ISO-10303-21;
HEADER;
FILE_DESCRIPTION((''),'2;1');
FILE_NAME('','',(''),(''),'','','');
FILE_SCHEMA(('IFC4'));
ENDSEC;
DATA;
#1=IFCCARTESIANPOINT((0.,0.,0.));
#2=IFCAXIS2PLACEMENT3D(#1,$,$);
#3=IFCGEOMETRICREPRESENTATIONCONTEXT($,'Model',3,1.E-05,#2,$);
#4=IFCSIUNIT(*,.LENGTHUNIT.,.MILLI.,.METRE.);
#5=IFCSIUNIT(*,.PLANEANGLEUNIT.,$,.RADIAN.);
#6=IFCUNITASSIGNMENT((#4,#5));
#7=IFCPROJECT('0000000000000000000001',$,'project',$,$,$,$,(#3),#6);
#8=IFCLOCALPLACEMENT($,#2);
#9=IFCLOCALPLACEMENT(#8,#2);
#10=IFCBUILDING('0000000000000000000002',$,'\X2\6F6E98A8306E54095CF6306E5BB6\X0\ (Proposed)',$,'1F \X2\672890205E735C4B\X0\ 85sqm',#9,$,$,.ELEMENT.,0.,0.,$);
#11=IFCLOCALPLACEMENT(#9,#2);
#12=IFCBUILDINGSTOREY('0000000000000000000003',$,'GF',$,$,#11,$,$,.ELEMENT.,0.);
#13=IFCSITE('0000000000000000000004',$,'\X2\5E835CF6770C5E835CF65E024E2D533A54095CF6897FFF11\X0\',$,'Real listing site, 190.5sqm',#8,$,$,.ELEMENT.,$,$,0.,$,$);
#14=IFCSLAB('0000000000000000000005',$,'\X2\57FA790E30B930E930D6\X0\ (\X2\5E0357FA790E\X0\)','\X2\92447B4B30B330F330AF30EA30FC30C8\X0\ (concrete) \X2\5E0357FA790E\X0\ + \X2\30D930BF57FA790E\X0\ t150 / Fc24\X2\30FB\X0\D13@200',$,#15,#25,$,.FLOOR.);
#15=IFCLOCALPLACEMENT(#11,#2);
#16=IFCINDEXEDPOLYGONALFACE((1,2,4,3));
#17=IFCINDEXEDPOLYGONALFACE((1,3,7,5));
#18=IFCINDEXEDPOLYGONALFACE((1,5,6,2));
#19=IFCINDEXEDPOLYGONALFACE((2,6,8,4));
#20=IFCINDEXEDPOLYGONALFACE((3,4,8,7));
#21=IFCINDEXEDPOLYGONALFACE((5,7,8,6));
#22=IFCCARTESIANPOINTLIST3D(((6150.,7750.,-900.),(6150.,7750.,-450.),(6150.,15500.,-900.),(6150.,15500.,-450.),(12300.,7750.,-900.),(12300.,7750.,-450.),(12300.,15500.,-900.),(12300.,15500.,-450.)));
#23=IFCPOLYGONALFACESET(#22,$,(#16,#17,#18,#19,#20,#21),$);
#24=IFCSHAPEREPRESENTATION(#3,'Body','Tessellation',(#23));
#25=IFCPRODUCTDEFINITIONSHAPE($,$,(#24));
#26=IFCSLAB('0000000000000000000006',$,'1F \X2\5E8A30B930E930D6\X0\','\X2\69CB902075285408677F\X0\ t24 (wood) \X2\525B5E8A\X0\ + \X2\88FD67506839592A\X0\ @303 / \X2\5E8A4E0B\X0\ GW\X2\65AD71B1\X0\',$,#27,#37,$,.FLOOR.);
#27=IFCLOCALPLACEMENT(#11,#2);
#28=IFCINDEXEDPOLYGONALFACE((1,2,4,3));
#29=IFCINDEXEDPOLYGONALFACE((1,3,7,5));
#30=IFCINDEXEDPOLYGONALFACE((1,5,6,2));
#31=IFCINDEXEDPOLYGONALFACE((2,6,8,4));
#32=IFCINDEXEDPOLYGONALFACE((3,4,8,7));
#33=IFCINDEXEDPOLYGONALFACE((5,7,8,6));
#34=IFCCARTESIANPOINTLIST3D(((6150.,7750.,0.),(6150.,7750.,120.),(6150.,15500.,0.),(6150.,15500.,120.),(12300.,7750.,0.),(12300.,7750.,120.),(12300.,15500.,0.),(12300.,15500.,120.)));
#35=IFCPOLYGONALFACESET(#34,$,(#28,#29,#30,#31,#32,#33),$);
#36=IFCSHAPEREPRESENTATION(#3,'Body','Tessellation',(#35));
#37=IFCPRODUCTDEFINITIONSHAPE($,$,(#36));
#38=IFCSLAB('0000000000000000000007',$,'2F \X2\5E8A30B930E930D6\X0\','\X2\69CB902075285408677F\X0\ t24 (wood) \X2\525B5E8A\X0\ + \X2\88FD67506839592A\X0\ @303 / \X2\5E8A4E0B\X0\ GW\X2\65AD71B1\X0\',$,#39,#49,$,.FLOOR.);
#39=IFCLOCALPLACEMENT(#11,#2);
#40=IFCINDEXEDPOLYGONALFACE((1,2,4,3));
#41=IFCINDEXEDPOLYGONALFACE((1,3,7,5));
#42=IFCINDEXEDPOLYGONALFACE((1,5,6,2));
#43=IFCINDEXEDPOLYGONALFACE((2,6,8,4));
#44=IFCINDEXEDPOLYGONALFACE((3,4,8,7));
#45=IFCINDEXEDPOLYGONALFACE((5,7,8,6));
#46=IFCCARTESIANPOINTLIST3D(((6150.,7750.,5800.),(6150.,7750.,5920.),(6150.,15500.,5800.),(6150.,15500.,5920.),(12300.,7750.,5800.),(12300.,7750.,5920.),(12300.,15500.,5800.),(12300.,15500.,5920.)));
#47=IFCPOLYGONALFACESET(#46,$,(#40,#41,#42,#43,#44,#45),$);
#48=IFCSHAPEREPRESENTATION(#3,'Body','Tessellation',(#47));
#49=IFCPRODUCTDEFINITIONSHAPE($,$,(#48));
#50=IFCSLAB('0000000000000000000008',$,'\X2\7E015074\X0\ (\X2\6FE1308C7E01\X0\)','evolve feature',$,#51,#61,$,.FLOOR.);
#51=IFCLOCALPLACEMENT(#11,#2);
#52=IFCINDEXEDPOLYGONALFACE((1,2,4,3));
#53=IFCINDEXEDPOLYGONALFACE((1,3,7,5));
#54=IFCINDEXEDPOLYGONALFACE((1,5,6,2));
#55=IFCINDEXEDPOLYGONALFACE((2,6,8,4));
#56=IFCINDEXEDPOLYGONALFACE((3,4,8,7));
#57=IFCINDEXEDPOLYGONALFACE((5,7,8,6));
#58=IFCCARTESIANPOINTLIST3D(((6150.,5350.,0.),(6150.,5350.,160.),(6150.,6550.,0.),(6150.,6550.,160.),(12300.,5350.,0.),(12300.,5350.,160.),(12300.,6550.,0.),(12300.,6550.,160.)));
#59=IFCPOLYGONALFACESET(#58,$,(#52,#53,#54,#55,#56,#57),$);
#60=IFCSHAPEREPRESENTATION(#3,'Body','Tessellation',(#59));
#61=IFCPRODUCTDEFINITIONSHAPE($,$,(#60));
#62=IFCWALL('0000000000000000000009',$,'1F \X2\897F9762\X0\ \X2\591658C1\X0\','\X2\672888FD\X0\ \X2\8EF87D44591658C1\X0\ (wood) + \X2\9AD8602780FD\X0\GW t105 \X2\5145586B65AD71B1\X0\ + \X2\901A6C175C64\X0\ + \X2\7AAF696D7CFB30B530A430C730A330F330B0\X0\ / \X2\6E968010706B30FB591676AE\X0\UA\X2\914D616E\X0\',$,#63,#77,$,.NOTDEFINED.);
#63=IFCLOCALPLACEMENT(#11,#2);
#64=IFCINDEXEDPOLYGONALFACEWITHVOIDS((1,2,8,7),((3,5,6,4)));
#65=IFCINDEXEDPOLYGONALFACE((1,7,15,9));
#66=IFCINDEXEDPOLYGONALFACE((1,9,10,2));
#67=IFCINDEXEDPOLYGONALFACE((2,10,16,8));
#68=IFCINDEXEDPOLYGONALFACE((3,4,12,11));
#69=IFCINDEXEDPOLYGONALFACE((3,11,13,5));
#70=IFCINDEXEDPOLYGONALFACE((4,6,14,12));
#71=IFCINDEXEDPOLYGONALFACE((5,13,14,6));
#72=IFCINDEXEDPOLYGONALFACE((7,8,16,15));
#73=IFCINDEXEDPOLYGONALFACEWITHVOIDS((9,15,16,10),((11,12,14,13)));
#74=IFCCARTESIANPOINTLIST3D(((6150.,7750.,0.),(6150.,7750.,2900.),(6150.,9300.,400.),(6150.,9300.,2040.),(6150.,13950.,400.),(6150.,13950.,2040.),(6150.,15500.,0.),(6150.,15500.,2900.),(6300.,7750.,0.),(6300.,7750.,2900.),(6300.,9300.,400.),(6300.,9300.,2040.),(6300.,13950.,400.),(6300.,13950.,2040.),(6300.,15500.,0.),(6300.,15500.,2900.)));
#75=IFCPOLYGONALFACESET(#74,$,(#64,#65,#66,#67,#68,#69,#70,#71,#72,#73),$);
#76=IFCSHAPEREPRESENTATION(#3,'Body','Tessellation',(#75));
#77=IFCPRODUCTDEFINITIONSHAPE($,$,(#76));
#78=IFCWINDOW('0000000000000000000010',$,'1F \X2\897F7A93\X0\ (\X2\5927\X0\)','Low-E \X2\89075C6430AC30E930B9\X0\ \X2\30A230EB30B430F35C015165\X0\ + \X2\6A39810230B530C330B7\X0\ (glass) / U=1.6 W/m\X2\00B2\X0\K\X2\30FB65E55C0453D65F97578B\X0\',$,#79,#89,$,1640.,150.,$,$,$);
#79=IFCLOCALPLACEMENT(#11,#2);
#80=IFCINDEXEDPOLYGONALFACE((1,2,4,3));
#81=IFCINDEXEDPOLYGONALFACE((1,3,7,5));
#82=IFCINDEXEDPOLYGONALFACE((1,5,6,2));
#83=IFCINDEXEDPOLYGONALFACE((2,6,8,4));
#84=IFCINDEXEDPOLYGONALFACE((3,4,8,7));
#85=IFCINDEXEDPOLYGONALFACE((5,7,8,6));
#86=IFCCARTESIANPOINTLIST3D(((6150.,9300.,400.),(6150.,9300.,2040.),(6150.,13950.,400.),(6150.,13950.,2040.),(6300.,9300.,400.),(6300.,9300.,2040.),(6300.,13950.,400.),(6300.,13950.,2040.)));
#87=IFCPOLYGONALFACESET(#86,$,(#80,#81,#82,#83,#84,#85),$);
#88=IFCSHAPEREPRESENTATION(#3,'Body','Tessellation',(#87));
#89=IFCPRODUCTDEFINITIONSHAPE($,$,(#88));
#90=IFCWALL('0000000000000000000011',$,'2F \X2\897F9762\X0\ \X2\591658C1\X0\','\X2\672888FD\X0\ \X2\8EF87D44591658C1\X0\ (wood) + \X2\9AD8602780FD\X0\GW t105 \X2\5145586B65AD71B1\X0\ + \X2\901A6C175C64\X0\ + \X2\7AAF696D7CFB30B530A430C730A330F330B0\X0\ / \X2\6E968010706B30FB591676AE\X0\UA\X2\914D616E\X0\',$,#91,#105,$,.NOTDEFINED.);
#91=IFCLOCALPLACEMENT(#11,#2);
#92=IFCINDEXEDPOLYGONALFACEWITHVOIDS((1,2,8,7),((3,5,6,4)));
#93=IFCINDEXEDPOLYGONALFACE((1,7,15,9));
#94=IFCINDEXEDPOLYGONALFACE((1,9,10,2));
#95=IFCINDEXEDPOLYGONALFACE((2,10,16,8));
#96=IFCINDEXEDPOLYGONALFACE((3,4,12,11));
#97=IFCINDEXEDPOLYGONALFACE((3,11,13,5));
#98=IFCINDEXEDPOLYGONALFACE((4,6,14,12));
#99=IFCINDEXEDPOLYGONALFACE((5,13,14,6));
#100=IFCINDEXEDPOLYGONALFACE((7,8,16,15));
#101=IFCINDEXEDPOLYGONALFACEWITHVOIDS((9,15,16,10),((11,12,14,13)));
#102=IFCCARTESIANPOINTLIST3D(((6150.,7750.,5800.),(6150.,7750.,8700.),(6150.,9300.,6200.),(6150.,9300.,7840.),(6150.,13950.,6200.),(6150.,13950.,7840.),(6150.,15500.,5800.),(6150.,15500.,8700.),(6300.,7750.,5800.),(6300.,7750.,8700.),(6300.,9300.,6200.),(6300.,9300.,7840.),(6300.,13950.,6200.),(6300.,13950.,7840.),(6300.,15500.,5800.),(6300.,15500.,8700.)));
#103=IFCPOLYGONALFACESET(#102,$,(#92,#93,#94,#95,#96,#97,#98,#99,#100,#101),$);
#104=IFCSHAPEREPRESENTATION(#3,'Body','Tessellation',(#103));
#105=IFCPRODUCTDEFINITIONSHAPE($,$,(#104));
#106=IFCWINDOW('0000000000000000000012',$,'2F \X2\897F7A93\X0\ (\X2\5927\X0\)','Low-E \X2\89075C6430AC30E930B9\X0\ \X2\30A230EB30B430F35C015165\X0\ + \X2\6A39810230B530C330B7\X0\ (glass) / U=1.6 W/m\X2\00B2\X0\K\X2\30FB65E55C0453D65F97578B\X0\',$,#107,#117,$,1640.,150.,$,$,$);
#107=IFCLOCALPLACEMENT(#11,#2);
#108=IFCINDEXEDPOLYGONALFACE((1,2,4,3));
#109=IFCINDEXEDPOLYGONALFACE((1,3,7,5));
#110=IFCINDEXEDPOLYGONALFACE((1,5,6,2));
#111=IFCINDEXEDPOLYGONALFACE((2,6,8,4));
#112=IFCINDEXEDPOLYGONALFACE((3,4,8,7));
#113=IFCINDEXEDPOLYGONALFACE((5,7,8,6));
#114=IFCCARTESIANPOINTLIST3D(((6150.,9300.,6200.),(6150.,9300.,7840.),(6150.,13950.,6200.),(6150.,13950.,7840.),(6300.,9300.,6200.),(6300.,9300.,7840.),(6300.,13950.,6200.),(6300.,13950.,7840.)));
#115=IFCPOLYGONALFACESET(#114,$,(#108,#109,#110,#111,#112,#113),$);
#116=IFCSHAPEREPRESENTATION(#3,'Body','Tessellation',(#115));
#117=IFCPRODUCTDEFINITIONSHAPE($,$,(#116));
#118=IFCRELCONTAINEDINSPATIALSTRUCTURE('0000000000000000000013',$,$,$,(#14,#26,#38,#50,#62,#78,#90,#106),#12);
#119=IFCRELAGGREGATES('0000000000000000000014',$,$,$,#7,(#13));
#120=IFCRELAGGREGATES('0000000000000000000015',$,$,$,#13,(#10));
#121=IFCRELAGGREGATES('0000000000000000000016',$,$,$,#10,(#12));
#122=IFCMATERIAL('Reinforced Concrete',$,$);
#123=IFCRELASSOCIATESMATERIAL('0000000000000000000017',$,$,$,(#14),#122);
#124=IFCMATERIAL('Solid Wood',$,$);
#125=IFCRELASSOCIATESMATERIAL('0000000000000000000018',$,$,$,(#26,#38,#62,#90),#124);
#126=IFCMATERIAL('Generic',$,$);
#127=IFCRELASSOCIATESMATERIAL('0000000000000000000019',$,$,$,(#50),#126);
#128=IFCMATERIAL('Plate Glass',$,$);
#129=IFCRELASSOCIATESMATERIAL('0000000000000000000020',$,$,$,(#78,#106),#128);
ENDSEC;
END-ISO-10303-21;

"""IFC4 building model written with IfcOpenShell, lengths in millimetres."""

from ifc_helpers import new_model, si_unit, frame, frame_2d, origin, place, context, project, spatial, rectangle, extrude, material, element, fill, save


model = new_model("IFC4")

# Units and contexts
model_context = context("Model", 3, precision=1e-05, world=origin())
ifc_project = project(units=[si_unit("LENGTHUNIT", "METRE", prefix="MILLI"), si_unit("PLANEANGLEUNIT", "RADIAN")], contexts=[model_context])

# Site, building, storey
site_placement = place(None, origin())
site = spatial("IfcSite", under=ifc_project, at=site_placement, Name="広島県広島市中区吉島西１", ObjectType="Real listing site, 190.5sqm", CompositionType="ELEMENT", RefElevation=0.0)
building_placement = place(site_placement, origin())
building = spatial("IfcBuilding", under=site, at=building_placement, Name="潮風の吉島の家 (Proposed)", ObjectType="1F 木造平屋 85sqm", CompositionType="ELEMENT", ElevationOfRefHeight=0.0, ElevationOfTerrain=0.0)
storey_placement = place(building_placement, origin())
storey = spatial("IfcBuildingStorey", under=building, at=storey_placement, Name="GF", CompositionType="ELEMENT", Elevation=0.0)

# Slabs
ifc_material_1 = material(Name="Reinforced Concrete")
slab_1_placement = place(storey_placement, frame((3075.0, 3875.0, -450.0)))
element("IfcSlab", 1, at=slab_1_placement, inside=storey, material=ifc_material_1, Name="基礎スラブ (布基礎)", Description="鉄筋コンクリート (concrete) 布基礎 + ベタ基礎 t150 / Fc24・D13@200", PredefinedType="FLOOR", context=model_context, shape_type="SweptSolid", body=[
    extrude(rectangle(XDim=6150.0, YDim=7750.0, at=frame_2d((3075.0, 3875.0))), frame((3075.0, 3875.0, -450.0)), (0.0, 0.0, 1.0), 450.0),
])
ifc_material_2 = material(Name="Solid Wood")
slab_2_placement = place(storey_placement, frame((3075.0, 3875.0, 0.0)))
element("IfcSlab", 2, at=slab_2_placement, inside=storey, material=ifc_material_2, Name="1F 床スラブ", Description="構造用合板 t24 (wood) 剛床 + 製材根太 @303 / 床下 GW断熱", PredefinedType="FLOOR", context=model_context, shape_type="SweptSolid", body=[
    extrude(rectangle(XDim=6150.0, YDim=7750.0, at=frame_2d((3075.0, 3875.0))), frame((3075.0, 3875.0, 0.0)), (0.0, 0.0, 1.0), 120.0),
])
slab_3_placement = place(storey_placement, frame((3075.0, 3875.0, 2900.0)))
element("IfcSlab", 3, at=slab_3_placement, inside=storey, material=ifc_material_2, Name="2F 床スラブ", Description="構造用合板 t24 (wood) 剛床 + 製材根太 @303 / 床下 GW断熱", PredefinedType="FLOOR", context=model_context, shape_type="SweptSolid", body=[
    extrude(rectangle(XDim=6150.0, YDim=7750.0, at=frame_2d((3075.0, 3875.0))), frame((3075.0, 3875.0, 2900.0)), (0.0, 0.0, 1.0), 120.0),
])
ifc_material_3 = material(Name="Generic")
slab_4_placement = place(storey_placement, frame((3075.0, 2675.0, 0.0)))
element("IfcSlab", 4, at=slab_4_placement, inside=storey, material=ifc_material_3, Name="縁側 (濡れ縁)", Description="evolve feature", PredefinedType="FLOOR", context=model_context, shape_type="SweptSolid", body=[
    extrude(rectangle(XDim=6150.0, YDim=1200.0, at=frame_2d((3075.0, 600.0))), frame((3075.0, 2675.0, 0.0)), (0.0, 0.0, 1.0), 160.0),
])

# Shared definitions
ifc_material_4 = material(Name="Plate Glass")

# Wall, opening, window
wall_1_placement = place(storey_placement, frame((3075.0, 3875.0, 0.0)))
wall_1 = element("IfcWall", 5, at=wall_1_placement, inside=storey, material=ifc_material_2, Name="1F 西面 外壁", Description="木製 軸組外壁 (wood) + 高性能GW t105 充填断熱 + 通気層 + 窯業系サイディング / 準耐火・外皮UA配慮", PredefinedType="NOTDEFINED", context=model_context, shape_type="SweptSolid", body=[
    extrude(rectangle(XDim=150.0, YDim=7750.0, at=frame_2d((75.0, 3875.0))), frame((3075.0, 3875.0, 0.0)), (0.0, 0.0, 1.0), 2900.0),
])
opening_1_placement = place(storey_placement, frame((3075.0, 4650.0, 200.0)))
opening_1 = element("IfcOpeningElement", 6, at=opening_1_placement, cuts=wall_1, PredefinedType="NOTDEFINED", context=model_context, shape_type="SweptSolid", body=[
    extrude(rectangle(XDim=150.0, YDim=4650.0, at=frame_2d((75.0, 2325.0))), frame((3075.0, 4650.0, 200.0)), (0.0, 0.0, 1.0), 1640.0),
])
window_1_placement = place(storey_placement, frame((3075.0, 4650.0, 200.0)))
window_1 = element("IfcWindow", 7, at=window_1_placement, inside=storey, material=ifc_material_4, Name="1F 西窓 (大)", Description="Low-E 複層ガラス アルゴン封入 + 樹脂サッシ (glass) / U=1.6 W/m²K・日射取得型", OverallHeight=1640.0, OverallWidth=150.0, context=model_context, shape_type="SweptSolid", body=[
    extrude(rectangle(XDim=150.0, YDim=4650.0, at=frame_2d((75.0, 2325.0))), frame((3075.0, 4650.0, 200.0)), (0.0, 0.0, 1.0), 1640.0),
])
fill(opening_1, window_1)

# Wall, opening, window
wall_2_placement = place(storey_placement, frame((3075.0, 3875.0, 2900.0)))
wall_2 = element("IfcWall", 8, at=wall_2_placement, inside=storey, material=ifc_material_2, Name="2F 西面 外壁", Description="木製 軸組外壁 (wood) + 高性能GW t105 充填断熱 + 通気層 + 窯業系サイディング / 準耐火・外皮UA配慮", PredefinedType="NOTDEFINED", context=model_context, shape_type="SweptSolid", body=[
    extrude(rectangle(XDim=150.0, YDim=7750.0, at=frame_2d((75.0, 3875.0))), frame((3075.0, 3875.0, 2900.0)), (0.0, 0.0, 1.0), 2900.0),
])
opening_2_placement = place(storey_placement, frame((3075.0, 4650.0, 3100.0)))
opening_2 = element("IfcOpeningElement", 9, at=opening_2_placement, cuts=wall_2, PredefinedType="NOTDEFINED", context=model_context, shape_type="SweptSolid", body=[
    extrude(rectangle(XDim=150.0, YDim=4650.0, at=frame_2d((75.0, 2325.0))), frame((3075.0, 4650.0, 3100.0)), (0.0, 0.0, 1.0), 1640.0),
])
window_2_placement = place(storey_placement, frame((3075.0, 4650.0, 3100.0)))
window_2 = element("IfcWindow", 10, at=window_2_placement, inside=storey, material=ifc_material_4, Name="2F 西窓 (大)", Description="Low-E 複層ガラス アルゴン封入 + 樹脂サッシ (glass) / U=1.6 W/m²K・日射取得型", OverallHeight=1640.0, OverallWidth=150.0, context=model_context, shape_type="SweptSolid", body=[
    extrude(rectangle(XDim=150.0, YDim=4650.0, at=frame_2d((75.0, 2325.0))), frame((3075.0, 4650.0, 3100.0)), (0.0, 0.0, 1.0), 1640.0),
])
fill(opening_2, window_2)

save(model, "model.ifc")
